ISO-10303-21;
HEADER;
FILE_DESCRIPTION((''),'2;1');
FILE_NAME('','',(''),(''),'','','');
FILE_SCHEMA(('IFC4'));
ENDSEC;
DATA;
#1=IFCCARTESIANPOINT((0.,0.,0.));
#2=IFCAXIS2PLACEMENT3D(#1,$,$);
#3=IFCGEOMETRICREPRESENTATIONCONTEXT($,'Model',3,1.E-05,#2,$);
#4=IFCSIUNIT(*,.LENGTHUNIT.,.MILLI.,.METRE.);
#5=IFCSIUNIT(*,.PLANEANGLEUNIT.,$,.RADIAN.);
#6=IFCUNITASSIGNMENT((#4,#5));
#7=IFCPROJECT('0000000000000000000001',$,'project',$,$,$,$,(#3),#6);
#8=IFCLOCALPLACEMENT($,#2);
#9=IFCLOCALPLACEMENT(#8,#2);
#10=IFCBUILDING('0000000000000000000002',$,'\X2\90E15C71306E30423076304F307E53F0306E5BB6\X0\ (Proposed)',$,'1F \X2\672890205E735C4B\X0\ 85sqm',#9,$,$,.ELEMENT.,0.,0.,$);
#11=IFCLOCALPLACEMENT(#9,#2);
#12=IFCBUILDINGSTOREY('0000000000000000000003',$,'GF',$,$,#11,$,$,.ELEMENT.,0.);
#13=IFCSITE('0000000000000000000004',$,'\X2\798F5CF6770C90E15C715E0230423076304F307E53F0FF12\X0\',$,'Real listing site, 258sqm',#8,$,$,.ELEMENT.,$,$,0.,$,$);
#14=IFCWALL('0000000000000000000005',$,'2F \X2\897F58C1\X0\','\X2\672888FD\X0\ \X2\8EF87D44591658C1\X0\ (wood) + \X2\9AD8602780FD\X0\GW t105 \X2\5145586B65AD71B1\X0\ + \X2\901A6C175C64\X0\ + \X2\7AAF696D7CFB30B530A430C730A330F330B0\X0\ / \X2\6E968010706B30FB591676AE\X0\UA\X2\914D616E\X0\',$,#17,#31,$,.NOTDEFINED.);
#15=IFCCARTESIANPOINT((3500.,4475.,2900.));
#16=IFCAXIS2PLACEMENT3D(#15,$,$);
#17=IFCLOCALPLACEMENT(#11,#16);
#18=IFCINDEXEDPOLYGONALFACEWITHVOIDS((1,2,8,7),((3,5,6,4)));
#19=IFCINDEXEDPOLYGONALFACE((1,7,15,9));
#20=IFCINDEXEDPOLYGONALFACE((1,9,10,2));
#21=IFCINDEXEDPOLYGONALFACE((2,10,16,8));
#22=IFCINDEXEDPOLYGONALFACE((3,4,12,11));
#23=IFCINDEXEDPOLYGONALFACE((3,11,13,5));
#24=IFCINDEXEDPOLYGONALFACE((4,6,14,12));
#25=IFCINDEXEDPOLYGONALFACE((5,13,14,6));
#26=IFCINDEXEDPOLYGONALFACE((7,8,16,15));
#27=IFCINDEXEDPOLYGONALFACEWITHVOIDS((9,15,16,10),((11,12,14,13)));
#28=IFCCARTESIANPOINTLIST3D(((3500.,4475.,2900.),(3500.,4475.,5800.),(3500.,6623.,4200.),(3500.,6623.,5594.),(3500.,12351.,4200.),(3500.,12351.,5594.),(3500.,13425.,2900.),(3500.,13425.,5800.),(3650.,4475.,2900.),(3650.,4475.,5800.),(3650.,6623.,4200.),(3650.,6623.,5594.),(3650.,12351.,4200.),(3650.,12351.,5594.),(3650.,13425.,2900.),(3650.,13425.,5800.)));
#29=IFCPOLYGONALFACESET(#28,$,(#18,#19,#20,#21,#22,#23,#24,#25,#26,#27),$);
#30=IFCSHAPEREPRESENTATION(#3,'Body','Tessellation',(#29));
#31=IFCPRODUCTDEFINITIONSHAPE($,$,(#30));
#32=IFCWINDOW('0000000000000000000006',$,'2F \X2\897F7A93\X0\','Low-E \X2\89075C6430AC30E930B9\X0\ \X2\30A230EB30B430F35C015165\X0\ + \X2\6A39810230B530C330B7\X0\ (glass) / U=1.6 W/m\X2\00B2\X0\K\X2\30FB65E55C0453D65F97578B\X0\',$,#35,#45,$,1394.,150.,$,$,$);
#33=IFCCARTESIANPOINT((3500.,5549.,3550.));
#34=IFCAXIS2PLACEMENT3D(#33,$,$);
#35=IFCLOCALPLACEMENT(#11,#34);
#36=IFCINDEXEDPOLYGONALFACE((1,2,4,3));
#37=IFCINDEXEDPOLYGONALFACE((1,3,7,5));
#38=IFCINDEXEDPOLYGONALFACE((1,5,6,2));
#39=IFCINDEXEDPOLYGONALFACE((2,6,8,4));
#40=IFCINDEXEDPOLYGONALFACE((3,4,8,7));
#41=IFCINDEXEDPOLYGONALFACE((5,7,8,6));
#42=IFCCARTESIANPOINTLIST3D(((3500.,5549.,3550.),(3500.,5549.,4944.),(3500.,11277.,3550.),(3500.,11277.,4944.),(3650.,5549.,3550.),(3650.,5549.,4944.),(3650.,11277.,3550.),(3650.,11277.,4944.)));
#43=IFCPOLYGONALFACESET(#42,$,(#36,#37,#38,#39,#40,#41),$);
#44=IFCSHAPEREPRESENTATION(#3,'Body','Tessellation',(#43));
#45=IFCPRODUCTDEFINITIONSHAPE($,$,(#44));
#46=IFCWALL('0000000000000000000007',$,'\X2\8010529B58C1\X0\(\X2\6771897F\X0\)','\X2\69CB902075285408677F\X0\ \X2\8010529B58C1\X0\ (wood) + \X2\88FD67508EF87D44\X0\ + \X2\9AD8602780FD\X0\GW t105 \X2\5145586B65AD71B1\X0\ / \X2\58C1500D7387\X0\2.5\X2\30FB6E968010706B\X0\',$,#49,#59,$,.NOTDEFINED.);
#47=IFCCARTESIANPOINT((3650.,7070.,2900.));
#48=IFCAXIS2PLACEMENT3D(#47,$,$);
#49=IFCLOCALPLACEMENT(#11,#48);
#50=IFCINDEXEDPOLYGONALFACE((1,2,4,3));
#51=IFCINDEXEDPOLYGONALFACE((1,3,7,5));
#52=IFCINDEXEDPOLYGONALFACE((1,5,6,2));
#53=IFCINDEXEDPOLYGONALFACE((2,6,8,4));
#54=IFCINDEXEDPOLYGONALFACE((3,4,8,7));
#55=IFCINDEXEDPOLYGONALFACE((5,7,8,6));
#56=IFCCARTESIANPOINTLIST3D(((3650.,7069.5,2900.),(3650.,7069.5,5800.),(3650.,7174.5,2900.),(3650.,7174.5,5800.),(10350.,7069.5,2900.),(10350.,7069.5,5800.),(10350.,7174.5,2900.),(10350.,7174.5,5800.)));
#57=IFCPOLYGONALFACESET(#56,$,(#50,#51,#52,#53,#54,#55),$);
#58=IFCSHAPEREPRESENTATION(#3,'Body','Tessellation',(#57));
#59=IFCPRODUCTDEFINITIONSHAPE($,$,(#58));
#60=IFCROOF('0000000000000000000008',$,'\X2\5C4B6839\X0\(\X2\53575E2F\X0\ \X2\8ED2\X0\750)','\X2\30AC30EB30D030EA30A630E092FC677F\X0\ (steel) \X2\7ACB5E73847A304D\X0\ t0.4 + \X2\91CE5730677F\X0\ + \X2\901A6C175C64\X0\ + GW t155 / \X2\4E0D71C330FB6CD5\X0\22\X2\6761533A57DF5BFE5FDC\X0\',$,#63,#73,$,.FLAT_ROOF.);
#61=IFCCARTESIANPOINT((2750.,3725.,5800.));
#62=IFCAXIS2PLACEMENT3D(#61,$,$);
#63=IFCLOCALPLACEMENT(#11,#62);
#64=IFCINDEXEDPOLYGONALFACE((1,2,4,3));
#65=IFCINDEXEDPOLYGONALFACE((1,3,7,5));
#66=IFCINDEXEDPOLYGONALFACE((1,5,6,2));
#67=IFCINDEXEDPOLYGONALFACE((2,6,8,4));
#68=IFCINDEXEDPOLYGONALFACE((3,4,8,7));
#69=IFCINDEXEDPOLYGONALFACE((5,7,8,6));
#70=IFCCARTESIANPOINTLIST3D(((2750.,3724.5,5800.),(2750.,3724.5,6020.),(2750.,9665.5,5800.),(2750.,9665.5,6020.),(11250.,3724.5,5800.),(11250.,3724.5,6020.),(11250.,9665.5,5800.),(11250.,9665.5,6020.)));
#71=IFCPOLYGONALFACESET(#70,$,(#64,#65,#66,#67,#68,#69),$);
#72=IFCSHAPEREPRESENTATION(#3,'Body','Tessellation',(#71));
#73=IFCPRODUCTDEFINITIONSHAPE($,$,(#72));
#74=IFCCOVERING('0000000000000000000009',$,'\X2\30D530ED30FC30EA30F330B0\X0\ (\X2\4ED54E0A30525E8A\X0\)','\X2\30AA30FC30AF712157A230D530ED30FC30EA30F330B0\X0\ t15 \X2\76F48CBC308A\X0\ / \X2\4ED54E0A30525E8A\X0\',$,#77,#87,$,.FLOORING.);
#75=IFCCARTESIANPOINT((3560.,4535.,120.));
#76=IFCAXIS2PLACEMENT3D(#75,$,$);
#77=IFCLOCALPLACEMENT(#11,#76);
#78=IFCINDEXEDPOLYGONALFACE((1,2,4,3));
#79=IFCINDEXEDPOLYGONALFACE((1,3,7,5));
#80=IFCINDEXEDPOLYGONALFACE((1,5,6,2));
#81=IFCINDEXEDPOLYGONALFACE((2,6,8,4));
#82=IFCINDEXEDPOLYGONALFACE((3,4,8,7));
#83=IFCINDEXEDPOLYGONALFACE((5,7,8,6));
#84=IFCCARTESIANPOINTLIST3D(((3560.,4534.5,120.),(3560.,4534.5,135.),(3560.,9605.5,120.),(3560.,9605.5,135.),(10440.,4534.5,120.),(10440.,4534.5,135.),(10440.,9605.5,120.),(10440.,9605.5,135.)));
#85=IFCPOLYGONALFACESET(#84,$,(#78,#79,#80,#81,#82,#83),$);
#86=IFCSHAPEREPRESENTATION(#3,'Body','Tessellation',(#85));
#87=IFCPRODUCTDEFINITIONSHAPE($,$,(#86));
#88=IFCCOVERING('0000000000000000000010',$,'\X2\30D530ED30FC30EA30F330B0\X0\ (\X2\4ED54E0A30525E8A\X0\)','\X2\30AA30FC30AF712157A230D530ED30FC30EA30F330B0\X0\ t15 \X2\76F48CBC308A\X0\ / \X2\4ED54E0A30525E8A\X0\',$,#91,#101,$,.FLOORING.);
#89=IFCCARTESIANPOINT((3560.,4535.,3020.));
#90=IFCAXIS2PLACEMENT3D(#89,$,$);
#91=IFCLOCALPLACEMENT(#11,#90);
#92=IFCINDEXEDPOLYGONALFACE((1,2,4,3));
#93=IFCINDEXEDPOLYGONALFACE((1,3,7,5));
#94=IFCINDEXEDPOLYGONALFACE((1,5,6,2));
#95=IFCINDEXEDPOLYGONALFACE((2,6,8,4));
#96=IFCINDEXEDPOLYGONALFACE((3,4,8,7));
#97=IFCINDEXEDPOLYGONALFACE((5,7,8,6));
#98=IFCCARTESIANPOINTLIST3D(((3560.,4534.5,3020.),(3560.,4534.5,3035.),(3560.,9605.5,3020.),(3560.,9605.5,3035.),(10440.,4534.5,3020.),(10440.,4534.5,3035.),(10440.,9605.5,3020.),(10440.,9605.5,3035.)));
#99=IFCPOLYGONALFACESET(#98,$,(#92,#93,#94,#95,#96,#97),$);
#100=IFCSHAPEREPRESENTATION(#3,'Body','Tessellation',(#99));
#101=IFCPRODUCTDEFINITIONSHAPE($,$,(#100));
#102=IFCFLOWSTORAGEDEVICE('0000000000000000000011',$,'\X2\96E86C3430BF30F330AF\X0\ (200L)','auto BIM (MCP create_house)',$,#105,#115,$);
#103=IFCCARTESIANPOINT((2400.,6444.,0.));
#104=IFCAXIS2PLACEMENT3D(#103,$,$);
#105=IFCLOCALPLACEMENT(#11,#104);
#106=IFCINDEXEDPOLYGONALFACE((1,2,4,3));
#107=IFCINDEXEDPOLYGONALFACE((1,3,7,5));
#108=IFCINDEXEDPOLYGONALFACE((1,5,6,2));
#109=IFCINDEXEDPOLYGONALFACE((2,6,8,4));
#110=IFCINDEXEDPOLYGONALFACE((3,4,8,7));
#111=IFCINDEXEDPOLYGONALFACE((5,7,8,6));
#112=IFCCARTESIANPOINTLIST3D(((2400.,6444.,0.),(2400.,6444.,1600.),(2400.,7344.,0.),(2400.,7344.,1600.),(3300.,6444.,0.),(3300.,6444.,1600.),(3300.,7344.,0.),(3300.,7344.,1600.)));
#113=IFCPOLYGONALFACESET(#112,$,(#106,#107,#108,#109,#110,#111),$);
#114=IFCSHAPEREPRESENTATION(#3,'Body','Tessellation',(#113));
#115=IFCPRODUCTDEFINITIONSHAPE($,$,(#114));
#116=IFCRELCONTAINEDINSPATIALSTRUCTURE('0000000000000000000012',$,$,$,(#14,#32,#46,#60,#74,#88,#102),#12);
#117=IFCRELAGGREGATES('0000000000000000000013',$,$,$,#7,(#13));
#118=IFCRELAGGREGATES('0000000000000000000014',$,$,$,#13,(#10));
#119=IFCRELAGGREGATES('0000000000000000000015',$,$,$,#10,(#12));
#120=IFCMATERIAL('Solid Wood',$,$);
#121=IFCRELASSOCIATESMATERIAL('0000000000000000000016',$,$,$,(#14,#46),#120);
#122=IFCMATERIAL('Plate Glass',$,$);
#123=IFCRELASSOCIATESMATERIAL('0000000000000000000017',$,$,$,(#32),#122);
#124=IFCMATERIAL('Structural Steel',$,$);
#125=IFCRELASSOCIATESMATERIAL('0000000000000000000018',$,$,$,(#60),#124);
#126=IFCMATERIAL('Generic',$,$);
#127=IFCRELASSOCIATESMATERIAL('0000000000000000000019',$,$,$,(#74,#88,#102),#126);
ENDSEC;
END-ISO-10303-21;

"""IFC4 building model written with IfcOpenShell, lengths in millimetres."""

from ifc_helpers import new_model, si_unit, frame, frame_2d, origin, place, context, project, spatial, rectangle, extrude, material, element, fill, save


model = new_model("IFC4")

# Units and contexts
model_context = context("Model", 3, precision=1e-05, world=origin())
ifc_project = project(units=[si_unit("LENGTHUNIT", "METRE", prefix="MILLI"), si_unit("PLANEANGLEUNIT", "RADIAN")], contexts=[model_context])

# Site, building, storey
site_placement = place(None, origin())
site = spatial("IfcSite", under=ifc_project, at=site_placement, Name="福島県郡山市あぶくま台２", ObjectType="Real listing site, 258sqm", CompositionType="ELEMENT", RefElevation=0.0)
building_placement = place(site_placement, origin())
building = spatial("IfcBuilding", under=site, at=building_placement, Name="郡山のあぶくま台の家 (Proposed)", ObjectType="1F 木造平屋 85sqm", CompositionType="ELEMENT", ElevationOfRefHeight=0.0, ElevationOfTerrain=0.0)
storey_placement = place(building_placement, origin())
storey = spatial("IfcBuildingStorey", under=building, at=storey_placement, Name="GF", CompositionType="ELEMENT", Elevation=0.0)

# Shared definitions
ifc_material_1 = material(Name="Solid Wood")
ifc_material_2 = material(Name="Generic")

# Shared definitions
ifc_material_3 = material(Name="Plate Glass")

# Wall, opening, window
wall_1_placement = place(storey_placement, frame((3500.0, 4475.0, 2900.0)))
wall_1 = element("IfcWall", 1, at=wall_1_placement, inside=storey, material=ifc_material_1, Name="2F 西壁", Description="木製 軸組外壁 (wood) + 高性能GW t105 充填断熱 + 通気層 + 窯業系サイディング / 準耐火・外皮UA配慮", PredefinedType="NOTDEFINED", context=model_context, shape_type="SweptSolid", body=[
    extrude(rectangle(XDim=150.0, YDim=8950.0, at=frame_2d((75.0, 4475.0))), frame((3500.0, 4475.0, 2900.0)), (0.0, 0.0, 1.0), 2900.0),
])
opening_1_placement = place(storey_placement, frame((3500.0, 5549.0, 3550.0)))
opening_1 = element("IfcOpeningElement", 2, at=opening_1_placement, cuts=wall_1, PredefinedType="NOTDEFINED", context=model_context, shape_type="SweptSolid", body=[
    extrude(rectangle(XDim=150.0, YDim=5728.0, at=frame_2d((75.0, 2864.0))), frame((3500.0, 5549.0, 3550.0)), (0.0, 0.0, 1.0), 1394.0),
])
window_1_placement = place(storey_placement, frame((3500.0, 5549.0, 3550.0)))
window_1 = element("IfcWindow", 3, at=window_1_placement, inside=storey, material=ifc_material_3, Name="2F 西窓", Description="Low-E 複層ガラス アルゴン封入 + 樹脂サッシ (glass) / U=1.6 W/m²K・日射取得型", OverallHeight=1394.0, OverallWidth=150.0, context=model_context, shape_type="SweptSolid", body=[
    extrude(rectangle(XDim=150.0, YDim=5728.0, at=frame_2d((75.0, 2864.0))), frame((3500.0, 5549.0, 3550.0)), (0.0, 0.0, 1.0), 1394.0),
])
fill(opening_1, window_1)

# Wall
wall_2_placement = place(storey_placement, frame((3650.0, 7070.0, 2900.0)))
element("IfcWall", 4, at=wall_2_placement, inside=storey, material=ifc_material_1, Name="耐力壁(東西)", Description="構造用合板 耐力壁 (wood) + 製材軸組 + 高性能GW t105 充填断熱 / 壁倍率2.5・準耐火", PredefinedType="NOTDEFINED", context=model_context, shape_type="SweptSolid", body=[
    extrude(rectangle(XDim=6700.0, YDim=105.0, at=frame_2d((3350.0, 52.0))), frame((3650.0, 7070.0, 2900.0)), (0.0, 0.0, 1.0), 2900.0),
])

# Roof
ifc_material_4 = material(Name="Structural Steel")
for number, where, name in (
    (5, (2750.0, 3725.0, 5800.0), "屋根(南帯 軒750)"),
):
    element("IfcRoof", number, at=place(storey_placement, frame(where)), inside=storey, material=ifc_material_4, Name=name, Description="ガルバリウム鋼板 (steel) 立平葺き t0.4 + 野地板 + 通気層 + GW t155 / 不燃・法22条区域対応", PredefinedType="FLAT_ROOF", context=model_context, shape_type="SweptSolid", body=[
        extrude(rectangle(XDim=8500.0, YDim=5941.0, at=frame_2d((4250.0, 2970.0))), frame((2750.0, 3725.0, 5800.0)), (0.0, 0.0, 1.0), 220.0),
    ])

# Coverings
covering_1_placement = place(storey_placement, frame((3560.0, 4535.0, 120.0)))
element("IfcCovering", 6, at=covering_1_placement, inside=storey, material=ifc_material_2, Name="フローリング (仕上げ床)", Description="オーク無垢フローリング t15 直貼り / 仕上げ床", PredefinedType="FLOORING", context=model_context, shape_type="SweptSolid", body=[
    extrude(rectangle(XDim=6880.0, YDim=5071.0, at=frame_2d((3440.0, 2535.0))), frame((3560.0, 4535.0, 120.0)), (0.0, 0.0, 1.0), 15.0),
])
covering_2_placement = place(storey_placement, frame((3560.0, 4535.0, 3020.0)))
element("IfcCovering", 7, at=covering_2_placement, inside=storey, material=ifc_material_2, Name="フローリング (仕上げ床)", Description="オーク無垢フローリング t15 直貼り / 仕上げ床", PredefinedType="FLOORING", context=model_context, shape_type="SweptSolid", body=[
    extrude(rectangle(XDim=6880.0, YDim=5071.0, at=frame_2d((3440.0, 2535.0))), frame((3560.0, 4535.0, 3020.0)), (0.0, 0.0, 1.0), 15.0),
])

# Flow storage device
flow_storage_device_placement = place(storey_placement, frame((2400.0, 6444.0, 0.0)))
element("IfcFlowStorageDevice", 8, at=flow_storage_device_placement, inside=storey, material=ifc_material_2, Name="雨水タンク (200L)", Description="auto BIM (MCP create_house)", context=model_context, shape_type="SweptSolid", body=[
    extrude(rectangle(XDim=900.0, YDim=900.0, at=frame_2d((450.0, 450.0))), frame((2400.0, 6444.0, 0.0)), (0.0, 0.0, 1.0), 1600.0),
])

save(model, "model.ifc")
